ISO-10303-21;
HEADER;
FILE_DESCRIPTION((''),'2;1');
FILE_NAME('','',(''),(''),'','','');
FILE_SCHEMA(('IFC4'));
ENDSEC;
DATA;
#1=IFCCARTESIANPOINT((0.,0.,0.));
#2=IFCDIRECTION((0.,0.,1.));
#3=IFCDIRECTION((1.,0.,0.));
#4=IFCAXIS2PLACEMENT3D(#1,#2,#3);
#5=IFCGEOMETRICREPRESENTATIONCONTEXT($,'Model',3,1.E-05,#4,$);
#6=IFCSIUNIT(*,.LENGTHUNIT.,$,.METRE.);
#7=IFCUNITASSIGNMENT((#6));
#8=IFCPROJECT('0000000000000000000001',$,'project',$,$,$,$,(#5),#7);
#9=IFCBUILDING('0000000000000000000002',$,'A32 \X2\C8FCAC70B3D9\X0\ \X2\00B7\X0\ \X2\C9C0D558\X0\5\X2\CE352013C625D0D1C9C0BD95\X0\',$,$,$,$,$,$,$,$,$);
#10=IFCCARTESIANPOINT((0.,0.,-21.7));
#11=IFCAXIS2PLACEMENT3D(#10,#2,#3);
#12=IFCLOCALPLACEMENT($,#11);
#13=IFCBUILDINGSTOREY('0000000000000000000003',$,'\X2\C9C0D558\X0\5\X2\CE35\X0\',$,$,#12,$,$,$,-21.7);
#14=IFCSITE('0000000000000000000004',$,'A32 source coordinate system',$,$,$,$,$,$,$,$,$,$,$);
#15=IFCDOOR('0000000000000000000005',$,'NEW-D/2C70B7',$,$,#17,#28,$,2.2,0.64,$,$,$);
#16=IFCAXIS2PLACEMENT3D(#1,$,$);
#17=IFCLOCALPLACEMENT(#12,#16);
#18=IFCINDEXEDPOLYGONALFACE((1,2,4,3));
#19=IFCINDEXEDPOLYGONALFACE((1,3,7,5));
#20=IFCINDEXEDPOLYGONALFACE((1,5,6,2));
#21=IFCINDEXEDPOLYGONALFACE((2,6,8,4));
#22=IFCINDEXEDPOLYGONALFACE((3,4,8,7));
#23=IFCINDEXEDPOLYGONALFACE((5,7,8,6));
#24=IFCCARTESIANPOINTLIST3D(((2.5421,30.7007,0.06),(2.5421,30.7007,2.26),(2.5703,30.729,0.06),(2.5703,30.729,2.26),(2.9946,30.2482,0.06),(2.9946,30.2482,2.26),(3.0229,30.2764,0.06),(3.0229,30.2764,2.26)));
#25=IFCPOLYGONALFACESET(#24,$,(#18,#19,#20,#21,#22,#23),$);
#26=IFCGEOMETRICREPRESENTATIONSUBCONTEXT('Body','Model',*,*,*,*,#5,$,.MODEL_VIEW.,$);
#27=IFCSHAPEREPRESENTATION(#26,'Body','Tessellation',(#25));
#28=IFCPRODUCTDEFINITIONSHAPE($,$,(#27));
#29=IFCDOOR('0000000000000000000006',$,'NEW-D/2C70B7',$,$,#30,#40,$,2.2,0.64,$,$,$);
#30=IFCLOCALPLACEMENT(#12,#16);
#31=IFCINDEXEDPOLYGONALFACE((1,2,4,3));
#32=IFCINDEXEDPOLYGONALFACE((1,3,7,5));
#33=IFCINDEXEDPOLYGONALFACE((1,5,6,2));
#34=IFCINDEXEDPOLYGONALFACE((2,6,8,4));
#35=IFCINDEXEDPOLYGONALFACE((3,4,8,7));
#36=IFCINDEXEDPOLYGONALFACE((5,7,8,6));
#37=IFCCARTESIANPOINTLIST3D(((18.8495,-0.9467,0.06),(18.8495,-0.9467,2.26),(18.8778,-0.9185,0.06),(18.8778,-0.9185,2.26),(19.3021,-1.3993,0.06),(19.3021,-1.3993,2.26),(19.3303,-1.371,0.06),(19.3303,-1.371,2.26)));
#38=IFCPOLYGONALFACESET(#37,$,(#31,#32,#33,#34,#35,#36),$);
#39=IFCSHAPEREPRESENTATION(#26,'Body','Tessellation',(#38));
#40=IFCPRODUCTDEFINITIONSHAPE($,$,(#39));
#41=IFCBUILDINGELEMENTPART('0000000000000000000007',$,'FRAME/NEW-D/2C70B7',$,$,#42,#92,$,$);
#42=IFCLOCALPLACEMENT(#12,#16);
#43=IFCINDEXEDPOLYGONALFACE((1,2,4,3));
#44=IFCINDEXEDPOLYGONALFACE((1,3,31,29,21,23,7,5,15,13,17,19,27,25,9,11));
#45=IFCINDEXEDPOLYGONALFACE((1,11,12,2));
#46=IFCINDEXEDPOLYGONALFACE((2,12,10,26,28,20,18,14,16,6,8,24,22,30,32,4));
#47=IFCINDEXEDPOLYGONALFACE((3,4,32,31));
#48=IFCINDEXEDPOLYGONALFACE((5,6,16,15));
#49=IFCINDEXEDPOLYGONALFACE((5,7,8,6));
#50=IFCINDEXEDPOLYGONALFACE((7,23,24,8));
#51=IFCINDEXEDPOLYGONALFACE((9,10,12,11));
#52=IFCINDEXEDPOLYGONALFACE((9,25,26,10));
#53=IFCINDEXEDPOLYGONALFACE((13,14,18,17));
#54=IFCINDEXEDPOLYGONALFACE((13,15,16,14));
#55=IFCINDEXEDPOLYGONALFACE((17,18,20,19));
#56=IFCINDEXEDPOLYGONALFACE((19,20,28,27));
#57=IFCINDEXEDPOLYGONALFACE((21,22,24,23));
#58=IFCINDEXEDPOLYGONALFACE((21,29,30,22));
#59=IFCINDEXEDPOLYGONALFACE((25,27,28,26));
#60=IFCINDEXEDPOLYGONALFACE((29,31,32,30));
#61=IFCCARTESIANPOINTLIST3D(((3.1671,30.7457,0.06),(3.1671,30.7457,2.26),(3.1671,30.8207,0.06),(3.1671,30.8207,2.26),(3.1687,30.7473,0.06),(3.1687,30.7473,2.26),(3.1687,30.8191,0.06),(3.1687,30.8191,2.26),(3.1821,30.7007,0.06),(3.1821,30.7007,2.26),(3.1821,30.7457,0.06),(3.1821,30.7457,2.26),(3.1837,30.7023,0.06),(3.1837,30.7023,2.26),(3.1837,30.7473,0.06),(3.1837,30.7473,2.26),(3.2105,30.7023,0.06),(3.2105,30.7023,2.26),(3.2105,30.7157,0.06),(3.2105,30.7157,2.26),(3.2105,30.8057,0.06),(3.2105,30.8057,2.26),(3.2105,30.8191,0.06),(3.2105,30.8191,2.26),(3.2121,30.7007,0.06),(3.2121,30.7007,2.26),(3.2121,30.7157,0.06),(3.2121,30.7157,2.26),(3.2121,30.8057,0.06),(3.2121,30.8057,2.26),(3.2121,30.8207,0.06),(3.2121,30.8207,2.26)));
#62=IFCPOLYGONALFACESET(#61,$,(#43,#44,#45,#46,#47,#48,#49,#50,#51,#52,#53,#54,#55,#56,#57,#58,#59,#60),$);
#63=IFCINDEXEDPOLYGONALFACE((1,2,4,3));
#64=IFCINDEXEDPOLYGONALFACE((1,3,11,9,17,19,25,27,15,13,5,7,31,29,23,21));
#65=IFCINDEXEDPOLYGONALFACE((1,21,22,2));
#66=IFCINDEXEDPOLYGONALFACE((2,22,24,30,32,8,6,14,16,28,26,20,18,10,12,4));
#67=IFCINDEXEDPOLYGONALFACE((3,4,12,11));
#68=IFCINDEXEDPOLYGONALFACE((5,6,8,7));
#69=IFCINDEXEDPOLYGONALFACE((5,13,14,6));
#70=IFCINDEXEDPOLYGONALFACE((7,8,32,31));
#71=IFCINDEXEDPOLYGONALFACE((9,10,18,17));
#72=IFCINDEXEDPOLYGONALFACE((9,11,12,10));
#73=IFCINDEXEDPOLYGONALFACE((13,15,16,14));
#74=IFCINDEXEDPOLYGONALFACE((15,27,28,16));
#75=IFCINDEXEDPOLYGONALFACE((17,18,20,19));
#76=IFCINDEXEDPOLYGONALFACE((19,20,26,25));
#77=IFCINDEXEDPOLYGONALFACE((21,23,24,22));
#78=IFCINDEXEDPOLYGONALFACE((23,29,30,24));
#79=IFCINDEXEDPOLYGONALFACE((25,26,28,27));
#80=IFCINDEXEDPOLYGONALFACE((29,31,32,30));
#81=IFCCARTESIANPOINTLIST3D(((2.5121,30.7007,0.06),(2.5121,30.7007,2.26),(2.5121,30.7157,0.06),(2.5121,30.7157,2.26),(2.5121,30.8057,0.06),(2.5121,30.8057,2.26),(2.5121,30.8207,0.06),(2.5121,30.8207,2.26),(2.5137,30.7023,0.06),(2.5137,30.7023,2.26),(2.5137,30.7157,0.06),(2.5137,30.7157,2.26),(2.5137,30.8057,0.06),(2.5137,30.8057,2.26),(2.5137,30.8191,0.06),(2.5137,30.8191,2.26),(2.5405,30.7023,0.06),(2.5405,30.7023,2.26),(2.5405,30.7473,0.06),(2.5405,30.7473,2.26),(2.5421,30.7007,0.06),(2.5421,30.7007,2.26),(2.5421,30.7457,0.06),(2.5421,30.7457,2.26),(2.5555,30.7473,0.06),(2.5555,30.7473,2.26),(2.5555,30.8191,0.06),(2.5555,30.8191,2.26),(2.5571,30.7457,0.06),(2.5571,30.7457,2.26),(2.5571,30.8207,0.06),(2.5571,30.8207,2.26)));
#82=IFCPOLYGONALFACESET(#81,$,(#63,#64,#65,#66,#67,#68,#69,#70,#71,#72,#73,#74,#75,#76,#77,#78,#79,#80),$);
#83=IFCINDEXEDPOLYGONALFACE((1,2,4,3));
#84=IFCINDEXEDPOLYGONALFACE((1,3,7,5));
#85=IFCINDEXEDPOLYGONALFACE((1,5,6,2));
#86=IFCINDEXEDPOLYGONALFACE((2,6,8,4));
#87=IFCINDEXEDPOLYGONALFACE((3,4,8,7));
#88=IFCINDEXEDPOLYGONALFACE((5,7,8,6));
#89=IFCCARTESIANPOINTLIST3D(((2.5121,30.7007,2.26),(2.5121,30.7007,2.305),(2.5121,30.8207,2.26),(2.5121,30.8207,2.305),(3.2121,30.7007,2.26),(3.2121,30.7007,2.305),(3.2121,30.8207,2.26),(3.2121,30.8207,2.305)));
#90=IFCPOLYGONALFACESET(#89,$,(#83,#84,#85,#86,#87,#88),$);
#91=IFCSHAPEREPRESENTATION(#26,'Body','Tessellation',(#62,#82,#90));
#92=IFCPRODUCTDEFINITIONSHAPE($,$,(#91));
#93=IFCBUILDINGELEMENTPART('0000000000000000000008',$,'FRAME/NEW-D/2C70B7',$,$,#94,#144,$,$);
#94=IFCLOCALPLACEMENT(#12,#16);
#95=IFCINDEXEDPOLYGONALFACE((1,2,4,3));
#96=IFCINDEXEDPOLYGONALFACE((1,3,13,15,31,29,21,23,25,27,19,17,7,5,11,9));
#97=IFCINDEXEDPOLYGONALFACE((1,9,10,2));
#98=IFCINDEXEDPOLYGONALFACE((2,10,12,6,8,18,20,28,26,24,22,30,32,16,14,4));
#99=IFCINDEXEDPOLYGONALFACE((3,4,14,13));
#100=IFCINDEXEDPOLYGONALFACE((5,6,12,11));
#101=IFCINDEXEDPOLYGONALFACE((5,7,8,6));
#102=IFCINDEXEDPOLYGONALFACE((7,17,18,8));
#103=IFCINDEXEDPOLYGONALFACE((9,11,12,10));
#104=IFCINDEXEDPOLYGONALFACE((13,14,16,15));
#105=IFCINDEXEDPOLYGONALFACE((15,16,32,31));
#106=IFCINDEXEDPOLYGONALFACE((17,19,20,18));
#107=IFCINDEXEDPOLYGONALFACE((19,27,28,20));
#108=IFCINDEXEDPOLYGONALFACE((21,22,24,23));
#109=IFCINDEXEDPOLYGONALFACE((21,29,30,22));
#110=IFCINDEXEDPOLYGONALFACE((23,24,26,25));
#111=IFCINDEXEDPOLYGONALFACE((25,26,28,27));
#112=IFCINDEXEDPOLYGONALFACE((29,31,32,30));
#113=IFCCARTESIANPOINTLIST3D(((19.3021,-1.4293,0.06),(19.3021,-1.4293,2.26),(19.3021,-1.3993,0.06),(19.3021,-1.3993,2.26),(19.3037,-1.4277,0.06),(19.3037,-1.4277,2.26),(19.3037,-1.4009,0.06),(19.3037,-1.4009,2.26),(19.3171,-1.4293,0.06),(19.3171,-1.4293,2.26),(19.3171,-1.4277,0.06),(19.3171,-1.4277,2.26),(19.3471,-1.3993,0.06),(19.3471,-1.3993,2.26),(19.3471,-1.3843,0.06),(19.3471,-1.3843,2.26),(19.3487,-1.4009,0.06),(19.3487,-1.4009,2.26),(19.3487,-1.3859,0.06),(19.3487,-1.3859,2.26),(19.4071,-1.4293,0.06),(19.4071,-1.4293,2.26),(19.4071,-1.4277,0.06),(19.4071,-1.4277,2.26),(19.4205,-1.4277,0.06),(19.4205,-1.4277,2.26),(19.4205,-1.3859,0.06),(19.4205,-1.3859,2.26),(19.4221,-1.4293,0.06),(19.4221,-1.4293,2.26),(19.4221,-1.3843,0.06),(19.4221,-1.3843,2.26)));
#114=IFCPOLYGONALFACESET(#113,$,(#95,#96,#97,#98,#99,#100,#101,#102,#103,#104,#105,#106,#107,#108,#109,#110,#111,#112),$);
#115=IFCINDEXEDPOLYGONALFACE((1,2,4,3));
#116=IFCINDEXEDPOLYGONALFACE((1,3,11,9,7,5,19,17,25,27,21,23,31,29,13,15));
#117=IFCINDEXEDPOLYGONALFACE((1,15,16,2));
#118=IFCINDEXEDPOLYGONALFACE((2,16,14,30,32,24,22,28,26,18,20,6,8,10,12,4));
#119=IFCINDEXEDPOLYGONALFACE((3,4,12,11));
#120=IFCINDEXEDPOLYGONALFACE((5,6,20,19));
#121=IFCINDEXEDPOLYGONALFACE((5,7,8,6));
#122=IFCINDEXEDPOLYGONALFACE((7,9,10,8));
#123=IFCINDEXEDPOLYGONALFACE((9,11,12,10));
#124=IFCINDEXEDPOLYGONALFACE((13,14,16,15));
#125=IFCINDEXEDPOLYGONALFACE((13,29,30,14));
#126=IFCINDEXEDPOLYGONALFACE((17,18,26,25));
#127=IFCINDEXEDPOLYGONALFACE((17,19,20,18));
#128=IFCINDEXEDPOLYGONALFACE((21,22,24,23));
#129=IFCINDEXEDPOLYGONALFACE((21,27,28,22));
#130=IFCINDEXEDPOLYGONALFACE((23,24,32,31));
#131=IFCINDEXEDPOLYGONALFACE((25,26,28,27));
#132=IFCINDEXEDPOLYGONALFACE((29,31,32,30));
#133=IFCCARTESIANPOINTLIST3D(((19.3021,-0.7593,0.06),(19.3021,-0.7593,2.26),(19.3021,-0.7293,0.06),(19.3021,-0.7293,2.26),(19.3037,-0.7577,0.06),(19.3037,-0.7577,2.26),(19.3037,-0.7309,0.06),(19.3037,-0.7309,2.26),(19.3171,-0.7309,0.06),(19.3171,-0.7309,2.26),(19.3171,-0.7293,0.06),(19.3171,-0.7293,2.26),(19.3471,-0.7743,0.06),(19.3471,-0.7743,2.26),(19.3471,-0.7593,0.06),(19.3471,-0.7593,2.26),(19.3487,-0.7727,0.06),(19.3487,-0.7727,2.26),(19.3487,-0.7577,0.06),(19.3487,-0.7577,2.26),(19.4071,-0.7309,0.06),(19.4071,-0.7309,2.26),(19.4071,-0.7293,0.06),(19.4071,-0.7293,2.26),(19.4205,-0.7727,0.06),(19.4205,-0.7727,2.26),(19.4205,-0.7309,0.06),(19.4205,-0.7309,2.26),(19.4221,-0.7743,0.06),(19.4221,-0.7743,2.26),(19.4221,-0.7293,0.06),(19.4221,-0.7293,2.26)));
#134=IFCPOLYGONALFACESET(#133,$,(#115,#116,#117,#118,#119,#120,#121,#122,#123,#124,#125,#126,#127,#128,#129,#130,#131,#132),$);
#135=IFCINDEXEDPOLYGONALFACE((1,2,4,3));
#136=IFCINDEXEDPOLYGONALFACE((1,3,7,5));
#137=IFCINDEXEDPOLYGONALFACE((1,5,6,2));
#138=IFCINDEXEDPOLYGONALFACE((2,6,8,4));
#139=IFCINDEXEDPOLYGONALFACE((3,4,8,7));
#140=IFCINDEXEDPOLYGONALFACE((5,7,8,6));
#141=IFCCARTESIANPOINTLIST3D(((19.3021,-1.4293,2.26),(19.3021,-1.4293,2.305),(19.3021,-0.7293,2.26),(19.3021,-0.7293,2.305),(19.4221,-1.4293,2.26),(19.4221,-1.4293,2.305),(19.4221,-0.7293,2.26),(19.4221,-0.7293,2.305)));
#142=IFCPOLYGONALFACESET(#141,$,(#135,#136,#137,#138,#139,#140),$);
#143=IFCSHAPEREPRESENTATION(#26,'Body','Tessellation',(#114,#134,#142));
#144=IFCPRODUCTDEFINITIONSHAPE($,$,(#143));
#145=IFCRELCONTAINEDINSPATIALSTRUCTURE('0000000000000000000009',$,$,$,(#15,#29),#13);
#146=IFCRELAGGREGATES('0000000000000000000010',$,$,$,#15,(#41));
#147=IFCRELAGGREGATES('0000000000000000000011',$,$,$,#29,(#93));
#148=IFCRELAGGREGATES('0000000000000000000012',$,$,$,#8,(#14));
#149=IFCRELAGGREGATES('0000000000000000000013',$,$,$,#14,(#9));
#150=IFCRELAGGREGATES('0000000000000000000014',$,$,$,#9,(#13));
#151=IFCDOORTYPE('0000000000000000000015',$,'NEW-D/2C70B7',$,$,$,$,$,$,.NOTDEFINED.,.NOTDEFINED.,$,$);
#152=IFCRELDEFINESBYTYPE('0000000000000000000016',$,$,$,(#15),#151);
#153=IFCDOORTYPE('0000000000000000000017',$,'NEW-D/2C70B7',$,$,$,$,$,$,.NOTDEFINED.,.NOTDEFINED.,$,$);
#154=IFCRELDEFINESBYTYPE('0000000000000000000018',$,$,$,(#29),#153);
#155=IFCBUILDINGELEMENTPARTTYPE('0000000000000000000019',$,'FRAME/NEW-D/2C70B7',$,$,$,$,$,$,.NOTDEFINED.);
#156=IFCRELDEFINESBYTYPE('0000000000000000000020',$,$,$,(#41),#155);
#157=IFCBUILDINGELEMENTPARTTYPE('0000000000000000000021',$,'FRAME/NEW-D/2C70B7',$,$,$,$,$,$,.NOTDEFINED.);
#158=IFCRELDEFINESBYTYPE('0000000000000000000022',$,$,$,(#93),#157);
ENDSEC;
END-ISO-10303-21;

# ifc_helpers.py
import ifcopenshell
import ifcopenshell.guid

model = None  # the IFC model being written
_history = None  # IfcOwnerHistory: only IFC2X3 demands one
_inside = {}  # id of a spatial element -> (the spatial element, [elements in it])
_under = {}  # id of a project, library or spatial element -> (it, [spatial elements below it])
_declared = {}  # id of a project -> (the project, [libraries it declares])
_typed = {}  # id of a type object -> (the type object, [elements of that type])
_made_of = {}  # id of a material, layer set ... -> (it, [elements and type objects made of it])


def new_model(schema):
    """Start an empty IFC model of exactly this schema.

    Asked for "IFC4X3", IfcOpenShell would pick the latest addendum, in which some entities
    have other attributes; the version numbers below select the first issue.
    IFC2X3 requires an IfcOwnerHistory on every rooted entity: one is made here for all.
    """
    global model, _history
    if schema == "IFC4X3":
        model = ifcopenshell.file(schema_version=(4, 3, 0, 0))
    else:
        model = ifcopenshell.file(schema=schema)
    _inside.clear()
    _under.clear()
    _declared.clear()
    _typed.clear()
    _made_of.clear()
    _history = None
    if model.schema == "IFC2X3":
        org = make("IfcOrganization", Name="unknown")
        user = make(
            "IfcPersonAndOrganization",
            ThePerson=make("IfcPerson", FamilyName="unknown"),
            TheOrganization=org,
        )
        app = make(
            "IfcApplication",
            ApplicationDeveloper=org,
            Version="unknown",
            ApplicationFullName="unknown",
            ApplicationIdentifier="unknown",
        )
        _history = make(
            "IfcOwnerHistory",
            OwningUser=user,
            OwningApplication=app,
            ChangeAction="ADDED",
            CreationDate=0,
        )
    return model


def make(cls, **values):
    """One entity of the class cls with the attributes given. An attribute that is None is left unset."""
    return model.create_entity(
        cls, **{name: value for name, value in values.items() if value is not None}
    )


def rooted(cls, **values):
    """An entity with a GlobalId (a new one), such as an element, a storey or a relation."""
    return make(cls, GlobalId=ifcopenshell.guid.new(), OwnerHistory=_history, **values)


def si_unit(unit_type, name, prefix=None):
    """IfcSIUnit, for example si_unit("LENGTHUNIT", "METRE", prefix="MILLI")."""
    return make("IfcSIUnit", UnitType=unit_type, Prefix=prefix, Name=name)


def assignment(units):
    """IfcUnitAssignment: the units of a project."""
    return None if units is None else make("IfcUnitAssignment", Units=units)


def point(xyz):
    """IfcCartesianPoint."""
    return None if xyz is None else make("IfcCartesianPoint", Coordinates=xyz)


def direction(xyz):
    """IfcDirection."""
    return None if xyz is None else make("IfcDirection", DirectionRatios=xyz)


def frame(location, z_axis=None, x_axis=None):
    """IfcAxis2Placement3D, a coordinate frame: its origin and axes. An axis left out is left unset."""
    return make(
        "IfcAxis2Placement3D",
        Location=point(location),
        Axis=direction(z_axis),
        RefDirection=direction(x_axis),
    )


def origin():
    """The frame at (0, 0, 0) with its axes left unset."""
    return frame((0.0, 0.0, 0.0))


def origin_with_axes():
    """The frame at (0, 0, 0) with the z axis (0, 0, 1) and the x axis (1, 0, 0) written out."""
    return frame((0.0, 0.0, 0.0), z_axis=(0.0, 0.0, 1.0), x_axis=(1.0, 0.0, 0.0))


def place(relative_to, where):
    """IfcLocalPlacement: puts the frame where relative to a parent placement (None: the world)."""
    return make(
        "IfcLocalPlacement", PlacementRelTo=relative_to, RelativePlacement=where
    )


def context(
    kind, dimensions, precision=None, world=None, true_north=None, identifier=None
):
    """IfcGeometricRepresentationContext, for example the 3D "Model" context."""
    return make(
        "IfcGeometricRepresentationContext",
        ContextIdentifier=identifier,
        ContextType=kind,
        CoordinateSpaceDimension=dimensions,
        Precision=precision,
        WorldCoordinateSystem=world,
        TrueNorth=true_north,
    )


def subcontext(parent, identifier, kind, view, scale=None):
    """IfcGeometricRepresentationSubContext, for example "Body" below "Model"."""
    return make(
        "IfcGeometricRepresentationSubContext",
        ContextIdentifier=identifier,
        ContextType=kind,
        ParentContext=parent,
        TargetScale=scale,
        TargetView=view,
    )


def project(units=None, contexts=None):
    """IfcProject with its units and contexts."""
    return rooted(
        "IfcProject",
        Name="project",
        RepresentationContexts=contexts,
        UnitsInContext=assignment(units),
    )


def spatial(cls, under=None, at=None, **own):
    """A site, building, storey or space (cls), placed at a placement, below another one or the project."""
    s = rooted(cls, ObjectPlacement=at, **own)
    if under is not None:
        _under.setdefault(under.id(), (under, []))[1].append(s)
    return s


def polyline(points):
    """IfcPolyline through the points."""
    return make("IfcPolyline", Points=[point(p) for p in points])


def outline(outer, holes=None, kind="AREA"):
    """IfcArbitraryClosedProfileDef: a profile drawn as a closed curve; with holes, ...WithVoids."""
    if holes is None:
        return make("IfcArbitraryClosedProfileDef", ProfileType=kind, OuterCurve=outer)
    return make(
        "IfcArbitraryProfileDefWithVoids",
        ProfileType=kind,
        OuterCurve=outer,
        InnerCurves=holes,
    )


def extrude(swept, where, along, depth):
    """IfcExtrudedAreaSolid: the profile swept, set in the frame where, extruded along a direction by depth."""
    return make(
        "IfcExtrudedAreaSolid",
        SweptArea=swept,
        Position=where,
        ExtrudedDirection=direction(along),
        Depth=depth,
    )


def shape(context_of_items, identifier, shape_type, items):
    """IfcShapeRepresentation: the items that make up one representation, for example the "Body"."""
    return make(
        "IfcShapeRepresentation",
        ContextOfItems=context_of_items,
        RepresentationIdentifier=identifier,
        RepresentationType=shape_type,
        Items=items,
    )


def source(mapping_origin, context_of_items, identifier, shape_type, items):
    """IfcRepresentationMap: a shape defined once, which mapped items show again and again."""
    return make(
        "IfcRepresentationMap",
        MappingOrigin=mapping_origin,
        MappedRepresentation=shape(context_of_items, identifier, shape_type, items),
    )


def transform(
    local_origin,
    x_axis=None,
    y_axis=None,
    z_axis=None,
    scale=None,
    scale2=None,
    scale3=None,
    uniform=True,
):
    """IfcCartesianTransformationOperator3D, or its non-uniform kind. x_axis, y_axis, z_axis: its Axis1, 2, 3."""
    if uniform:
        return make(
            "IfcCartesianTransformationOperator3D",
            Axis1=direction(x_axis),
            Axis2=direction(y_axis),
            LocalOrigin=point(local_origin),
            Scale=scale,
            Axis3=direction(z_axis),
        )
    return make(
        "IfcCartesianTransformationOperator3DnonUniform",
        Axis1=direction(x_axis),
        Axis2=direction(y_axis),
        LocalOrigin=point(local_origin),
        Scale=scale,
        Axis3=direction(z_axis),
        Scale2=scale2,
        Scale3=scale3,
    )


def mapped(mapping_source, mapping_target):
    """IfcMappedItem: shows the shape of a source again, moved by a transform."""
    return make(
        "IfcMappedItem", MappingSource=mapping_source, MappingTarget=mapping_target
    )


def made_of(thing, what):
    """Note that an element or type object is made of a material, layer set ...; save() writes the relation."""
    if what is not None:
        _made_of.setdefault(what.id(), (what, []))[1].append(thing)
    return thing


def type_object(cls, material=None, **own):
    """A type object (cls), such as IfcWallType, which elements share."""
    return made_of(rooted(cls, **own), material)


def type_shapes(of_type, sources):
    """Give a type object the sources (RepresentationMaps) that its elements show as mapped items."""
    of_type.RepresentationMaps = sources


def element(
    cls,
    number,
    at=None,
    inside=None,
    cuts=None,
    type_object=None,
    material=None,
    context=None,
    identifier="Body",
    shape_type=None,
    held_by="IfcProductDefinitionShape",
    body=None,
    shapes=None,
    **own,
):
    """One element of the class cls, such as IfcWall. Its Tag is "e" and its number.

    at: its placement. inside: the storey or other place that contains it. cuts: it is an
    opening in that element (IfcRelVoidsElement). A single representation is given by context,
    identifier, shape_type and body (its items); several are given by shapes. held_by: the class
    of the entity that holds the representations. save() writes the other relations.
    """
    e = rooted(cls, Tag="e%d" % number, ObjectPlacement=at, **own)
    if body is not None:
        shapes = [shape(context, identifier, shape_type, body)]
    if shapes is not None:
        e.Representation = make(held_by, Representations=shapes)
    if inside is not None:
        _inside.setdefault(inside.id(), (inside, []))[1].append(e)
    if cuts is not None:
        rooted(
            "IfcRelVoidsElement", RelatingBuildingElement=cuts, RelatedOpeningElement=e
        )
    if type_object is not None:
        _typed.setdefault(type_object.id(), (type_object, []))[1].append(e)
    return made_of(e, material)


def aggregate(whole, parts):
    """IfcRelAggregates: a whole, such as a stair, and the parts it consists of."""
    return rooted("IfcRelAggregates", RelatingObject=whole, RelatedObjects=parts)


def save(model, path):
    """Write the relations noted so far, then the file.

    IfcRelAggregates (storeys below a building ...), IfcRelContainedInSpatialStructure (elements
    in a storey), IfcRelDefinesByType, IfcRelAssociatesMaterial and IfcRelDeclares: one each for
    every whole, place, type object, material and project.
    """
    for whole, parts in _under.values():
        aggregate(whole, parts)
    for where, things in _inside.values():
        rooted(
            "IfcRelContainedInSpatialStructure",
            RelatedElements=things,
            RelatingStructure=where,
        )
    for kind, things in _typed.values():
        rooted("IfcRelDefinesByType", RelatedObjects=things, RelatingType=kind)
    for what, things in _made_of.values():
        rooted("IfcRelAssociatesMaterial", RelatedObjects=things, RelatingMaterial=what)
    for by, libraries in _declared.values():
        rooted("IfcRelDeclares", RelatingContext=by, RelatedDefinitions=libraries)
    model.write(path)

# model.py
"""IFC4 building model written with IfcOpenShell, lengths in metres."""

from ifc_helpers import new_model, si_unit, frame, origin, origin_with_axes, place, context, subcontext, project, spatial, polyline, outline, extrude, source, transform, mapped, type_object, type_shapes, element, aggregate, save


model = new_model("IFC4")

# Units and contexts
model_context = context("Model", 3, precision=1e-05, world=origin_with_axes())
body_context = subcontext(model_context, "Body", "Model", "MODEL_VIEW")
ifc_project = project(units=[si_unit("LENGTHUNIT", "METRE")], contexts=[model_context])

# Site, building, storey
site = spatial("IfcSite", under=ifc_project, Name="A32 source coordinate system")
building = spatial("IfcBuilding", under=site, Name="A32 주거동 · 지하5층–옥탑지붕")
storey_placement = place(None, frame((0.0, 0.0, -21.7), z_axis=(0.0, 0.0, 1.0), x_axis=(1.0, 0.0, 0.0)))
storey = spatial("IfcBuildingStorey", under=building, at=storey_placement, Name="지하5층", Elevation=-21.7)

# Doors
door_type_1 = type_object("IfcDoorType", Name="NEW-D/2C70B7", OperationType="NOTDEFINED", PredefinedType="NOTDEFINED")
shared_shape_1 = source(origin(), body_context, "Body", "SweptSolid", [
    extrude(outline(polyline([(2.5421, 30.7007), (2.5703, 30.729), (3.0229, 30.2764), (2.9946, 30.2482), (2.5421, 30.7007)])), frame((0.0, 0.0, 0.06)), (0.0, 0.0, 1.0), 2.2),
])
type_shapes(door_type_1, [shared_shape_1])
door_1_placement = place(storey_placement, origin_with_axes())
door_1 = element("IfcDoor", 1, at=door_1_placement, inside=storey, type_object=door_type_1, Name="NEW-D/2C70B7", OverallHeight=2.2, OverallWidth=0.64, context=body_context, shape_type="MappedRepresentation", body=[
    mapped(shared_shape_1, transform((0.0, 0.0, 0.0), scale=1.0)),
])
door_type_2 = type_object("IfcDoorType", Name="NEW-D/2C70B7", OperationType="NOTDEFINED", PredefinedType="NOTDEFINED")
shared_shape_2 = source(origin(), body_context, "Body", "SweptSolid", [
    extrude(outline(polyline([(18.8778, -0.9185), (19.3303, -1.371), (19.3021, -1.3993), (18.8495, -0.9467), (18.8778, -0.9185)])), frame((0.0, 0.0, 0.06)), (0.0, 0.0, 1.0), 2.2),
])
type_shapes(door_type_2, [shared_shape_2])
door_2_placement = place(storey_placement, origin_with_axes())
door_2 = element("IfcDoor", 2, at=door_2_placement, inside=storey, type_object=door_type_2, Name="NEW-D/2C70B7", OverallHeight=2.2, OverallWidth=0.64, context=body_context, shape_type="MappedRepresentation", body=[
    mapped(shared_shape_2, transform((0.0, 0.0, 0.0), scale=1.0)),
])

# Building element parts
building_element_part_type_1 = type_object("IfcBuildingElementPartType", Name="FRAME/NEW-D/2C70B7", PredefinedType="NOTDEFINED")
shared_shape_3 = source(origin(), body_context, "Body", "SweptSolid", [
    extrude(outline(polyline([(3.2121, 30.7007), (3.1821, 30.7007), (3.1821, 30.7457), (3.1671, 30.7457), (3.1671, 30.8207), (3.2121, 30.8207), (3.2121, 30.8057), (3.2105, 30.8057), (3.2105, 30.8191), (3.1687, 30.8191), (3.1687, 30.7473), (3.1837, 30.7473), (3.1837, 30.7023), (3.2105, 30.7023), (3.2105, 30.7157), (3.2121, 30.7157), (3.2121, 30.7007)])), frame((0.0, 0.0, 0.06)), (0.0, 0.0, 1.0), 2.2),
    extrude(outline(polyline([(2.5405, 30.7023), (2.5405, 30.7473), (2.5555, 30.7473), (2.5555, 30.8191), (2.5137, 30.8191), (2.5137, 30.8057), (2.5121, 30.8057), (2.5121, 30.8207), (2.5571, 30.8207), (2.5571, 30.7457), (2.5421, 30.7457), (2.5421, 30.7007), (2.5121, 30.7007), (2.5121, 30.7157), (2.5137, 30.7157), (2.5137, 30.7023), (2.5405, 30.7023)])), frame((0.0, 0.0, 0.06)), (0.0, 0.0, 1.0), 2.2),
    extrude(outline(polyline([(3.2121, 30.7007), (3.2121, 30.8207), (2.5121, 30.8207), (2.5121, 30.7007), (3.2121, 30.7007)])), frame((0.0, 0.0, 2.26)), (0.0, 0.0, 1.0), 0.045),
])
type_shapes(building_element_part_type_1, [shared_shape_3])
building_element_part_1_placement = place(door_1_placement, origin_with_axes())
building_element_part_1 = element("IfcBuildingElementPart", 3, at=building_element_part_1_placement, type_object=building_element_part_type_1, Name="FRAME/NEW-D/2C70B7", context=body_context, shape_type="MappedRepresentation", body=[
    mapped(shared_shape_3, transform((0.0, 0.0, 0.0), scale=1.0)),
])
aggregate(door_1, [building_element_part_1])
building_element_part_type_2 = type_object("IfcBuildingElementPartType", Name="FRAME/NEW-D/2C70B7", PredefinedType="NOTDEFINED")
shared_shape_4 = source(origin(), body_context, "Body", "SweptSolid", [
    extrude(outline(polyline([(19.3021, -1.4293), (19.3021, -1.3993), (19.3471, -1.3993), (19.3471, -1.3843), (19.4221, -1.3843), (19.4221, -1.4293), (19.4071, -1.4293), (19.4071, -1.4277), (19.4205, -1.4277), (19.4205, -1.3859), (19.3487, -1.3859), (19.3487, -1.4009), (19.3037, -1.4009), (19.3037, -1.4277), (19.3171, -1.4277), (19.3171, -1.4293), (19.3021, -1.4293)])), frame((0.0, 0.0, 0.06)), (0.0, 0.0, 1.0), 2.2),
    extrude(outline(polyline([(19.3037, -0.7577), (19.3487, -0.7577), (19.3487, -0.7727), (19.4205, -0.7727), (19.4205, -0.7309), (19.4071, -0.7309), (19.4071, -0.7293), (19.4221, -0.7293), (19.4221, -0.7743), (19.3471, -0.7743), (19.3471, -0.7593), (19.3021, -0.7593), (19.3021, -0.7293), (19.3171, -0.7293), (19.3171, -0.7309), (19.3037, -0.7309), (19.3037, -0.7577)])), frame((0.0, 0.0, 0.06)), (0.0, 0.0, 1.0), 2.2),
    extrude(outline(polyline([(19.4221, -1.4293), (19.4221, -0.7293), (19.3021, -0.7293), (19.3021, -1.4293), (19.4221, -1.4293)])), frame((0.0, 0.0, 2.26)), (0.0, 0.0, 1.0), 0.045),
])
type_shapes(building_element_part_type_2, [shared_shape_4])
building_element_part_2_placement = place(door_2_placement, origin_with_axes())
building_element_part_2 = element("IfcBuildingElementPart", 4, at=building_element_part_2_placement, type_object=building_element_part_type_2, Name="FRAME/NEW-D/2C70B7", context=body_context, shape_type="MappedRepresentation", body=[
    mapped(shared_shape_4, transform((0.0, 0.0, 0.0), scale=1.0)),
])
aggregate(door_2, [building_element_part_2])

save(model, "model.ifc")
